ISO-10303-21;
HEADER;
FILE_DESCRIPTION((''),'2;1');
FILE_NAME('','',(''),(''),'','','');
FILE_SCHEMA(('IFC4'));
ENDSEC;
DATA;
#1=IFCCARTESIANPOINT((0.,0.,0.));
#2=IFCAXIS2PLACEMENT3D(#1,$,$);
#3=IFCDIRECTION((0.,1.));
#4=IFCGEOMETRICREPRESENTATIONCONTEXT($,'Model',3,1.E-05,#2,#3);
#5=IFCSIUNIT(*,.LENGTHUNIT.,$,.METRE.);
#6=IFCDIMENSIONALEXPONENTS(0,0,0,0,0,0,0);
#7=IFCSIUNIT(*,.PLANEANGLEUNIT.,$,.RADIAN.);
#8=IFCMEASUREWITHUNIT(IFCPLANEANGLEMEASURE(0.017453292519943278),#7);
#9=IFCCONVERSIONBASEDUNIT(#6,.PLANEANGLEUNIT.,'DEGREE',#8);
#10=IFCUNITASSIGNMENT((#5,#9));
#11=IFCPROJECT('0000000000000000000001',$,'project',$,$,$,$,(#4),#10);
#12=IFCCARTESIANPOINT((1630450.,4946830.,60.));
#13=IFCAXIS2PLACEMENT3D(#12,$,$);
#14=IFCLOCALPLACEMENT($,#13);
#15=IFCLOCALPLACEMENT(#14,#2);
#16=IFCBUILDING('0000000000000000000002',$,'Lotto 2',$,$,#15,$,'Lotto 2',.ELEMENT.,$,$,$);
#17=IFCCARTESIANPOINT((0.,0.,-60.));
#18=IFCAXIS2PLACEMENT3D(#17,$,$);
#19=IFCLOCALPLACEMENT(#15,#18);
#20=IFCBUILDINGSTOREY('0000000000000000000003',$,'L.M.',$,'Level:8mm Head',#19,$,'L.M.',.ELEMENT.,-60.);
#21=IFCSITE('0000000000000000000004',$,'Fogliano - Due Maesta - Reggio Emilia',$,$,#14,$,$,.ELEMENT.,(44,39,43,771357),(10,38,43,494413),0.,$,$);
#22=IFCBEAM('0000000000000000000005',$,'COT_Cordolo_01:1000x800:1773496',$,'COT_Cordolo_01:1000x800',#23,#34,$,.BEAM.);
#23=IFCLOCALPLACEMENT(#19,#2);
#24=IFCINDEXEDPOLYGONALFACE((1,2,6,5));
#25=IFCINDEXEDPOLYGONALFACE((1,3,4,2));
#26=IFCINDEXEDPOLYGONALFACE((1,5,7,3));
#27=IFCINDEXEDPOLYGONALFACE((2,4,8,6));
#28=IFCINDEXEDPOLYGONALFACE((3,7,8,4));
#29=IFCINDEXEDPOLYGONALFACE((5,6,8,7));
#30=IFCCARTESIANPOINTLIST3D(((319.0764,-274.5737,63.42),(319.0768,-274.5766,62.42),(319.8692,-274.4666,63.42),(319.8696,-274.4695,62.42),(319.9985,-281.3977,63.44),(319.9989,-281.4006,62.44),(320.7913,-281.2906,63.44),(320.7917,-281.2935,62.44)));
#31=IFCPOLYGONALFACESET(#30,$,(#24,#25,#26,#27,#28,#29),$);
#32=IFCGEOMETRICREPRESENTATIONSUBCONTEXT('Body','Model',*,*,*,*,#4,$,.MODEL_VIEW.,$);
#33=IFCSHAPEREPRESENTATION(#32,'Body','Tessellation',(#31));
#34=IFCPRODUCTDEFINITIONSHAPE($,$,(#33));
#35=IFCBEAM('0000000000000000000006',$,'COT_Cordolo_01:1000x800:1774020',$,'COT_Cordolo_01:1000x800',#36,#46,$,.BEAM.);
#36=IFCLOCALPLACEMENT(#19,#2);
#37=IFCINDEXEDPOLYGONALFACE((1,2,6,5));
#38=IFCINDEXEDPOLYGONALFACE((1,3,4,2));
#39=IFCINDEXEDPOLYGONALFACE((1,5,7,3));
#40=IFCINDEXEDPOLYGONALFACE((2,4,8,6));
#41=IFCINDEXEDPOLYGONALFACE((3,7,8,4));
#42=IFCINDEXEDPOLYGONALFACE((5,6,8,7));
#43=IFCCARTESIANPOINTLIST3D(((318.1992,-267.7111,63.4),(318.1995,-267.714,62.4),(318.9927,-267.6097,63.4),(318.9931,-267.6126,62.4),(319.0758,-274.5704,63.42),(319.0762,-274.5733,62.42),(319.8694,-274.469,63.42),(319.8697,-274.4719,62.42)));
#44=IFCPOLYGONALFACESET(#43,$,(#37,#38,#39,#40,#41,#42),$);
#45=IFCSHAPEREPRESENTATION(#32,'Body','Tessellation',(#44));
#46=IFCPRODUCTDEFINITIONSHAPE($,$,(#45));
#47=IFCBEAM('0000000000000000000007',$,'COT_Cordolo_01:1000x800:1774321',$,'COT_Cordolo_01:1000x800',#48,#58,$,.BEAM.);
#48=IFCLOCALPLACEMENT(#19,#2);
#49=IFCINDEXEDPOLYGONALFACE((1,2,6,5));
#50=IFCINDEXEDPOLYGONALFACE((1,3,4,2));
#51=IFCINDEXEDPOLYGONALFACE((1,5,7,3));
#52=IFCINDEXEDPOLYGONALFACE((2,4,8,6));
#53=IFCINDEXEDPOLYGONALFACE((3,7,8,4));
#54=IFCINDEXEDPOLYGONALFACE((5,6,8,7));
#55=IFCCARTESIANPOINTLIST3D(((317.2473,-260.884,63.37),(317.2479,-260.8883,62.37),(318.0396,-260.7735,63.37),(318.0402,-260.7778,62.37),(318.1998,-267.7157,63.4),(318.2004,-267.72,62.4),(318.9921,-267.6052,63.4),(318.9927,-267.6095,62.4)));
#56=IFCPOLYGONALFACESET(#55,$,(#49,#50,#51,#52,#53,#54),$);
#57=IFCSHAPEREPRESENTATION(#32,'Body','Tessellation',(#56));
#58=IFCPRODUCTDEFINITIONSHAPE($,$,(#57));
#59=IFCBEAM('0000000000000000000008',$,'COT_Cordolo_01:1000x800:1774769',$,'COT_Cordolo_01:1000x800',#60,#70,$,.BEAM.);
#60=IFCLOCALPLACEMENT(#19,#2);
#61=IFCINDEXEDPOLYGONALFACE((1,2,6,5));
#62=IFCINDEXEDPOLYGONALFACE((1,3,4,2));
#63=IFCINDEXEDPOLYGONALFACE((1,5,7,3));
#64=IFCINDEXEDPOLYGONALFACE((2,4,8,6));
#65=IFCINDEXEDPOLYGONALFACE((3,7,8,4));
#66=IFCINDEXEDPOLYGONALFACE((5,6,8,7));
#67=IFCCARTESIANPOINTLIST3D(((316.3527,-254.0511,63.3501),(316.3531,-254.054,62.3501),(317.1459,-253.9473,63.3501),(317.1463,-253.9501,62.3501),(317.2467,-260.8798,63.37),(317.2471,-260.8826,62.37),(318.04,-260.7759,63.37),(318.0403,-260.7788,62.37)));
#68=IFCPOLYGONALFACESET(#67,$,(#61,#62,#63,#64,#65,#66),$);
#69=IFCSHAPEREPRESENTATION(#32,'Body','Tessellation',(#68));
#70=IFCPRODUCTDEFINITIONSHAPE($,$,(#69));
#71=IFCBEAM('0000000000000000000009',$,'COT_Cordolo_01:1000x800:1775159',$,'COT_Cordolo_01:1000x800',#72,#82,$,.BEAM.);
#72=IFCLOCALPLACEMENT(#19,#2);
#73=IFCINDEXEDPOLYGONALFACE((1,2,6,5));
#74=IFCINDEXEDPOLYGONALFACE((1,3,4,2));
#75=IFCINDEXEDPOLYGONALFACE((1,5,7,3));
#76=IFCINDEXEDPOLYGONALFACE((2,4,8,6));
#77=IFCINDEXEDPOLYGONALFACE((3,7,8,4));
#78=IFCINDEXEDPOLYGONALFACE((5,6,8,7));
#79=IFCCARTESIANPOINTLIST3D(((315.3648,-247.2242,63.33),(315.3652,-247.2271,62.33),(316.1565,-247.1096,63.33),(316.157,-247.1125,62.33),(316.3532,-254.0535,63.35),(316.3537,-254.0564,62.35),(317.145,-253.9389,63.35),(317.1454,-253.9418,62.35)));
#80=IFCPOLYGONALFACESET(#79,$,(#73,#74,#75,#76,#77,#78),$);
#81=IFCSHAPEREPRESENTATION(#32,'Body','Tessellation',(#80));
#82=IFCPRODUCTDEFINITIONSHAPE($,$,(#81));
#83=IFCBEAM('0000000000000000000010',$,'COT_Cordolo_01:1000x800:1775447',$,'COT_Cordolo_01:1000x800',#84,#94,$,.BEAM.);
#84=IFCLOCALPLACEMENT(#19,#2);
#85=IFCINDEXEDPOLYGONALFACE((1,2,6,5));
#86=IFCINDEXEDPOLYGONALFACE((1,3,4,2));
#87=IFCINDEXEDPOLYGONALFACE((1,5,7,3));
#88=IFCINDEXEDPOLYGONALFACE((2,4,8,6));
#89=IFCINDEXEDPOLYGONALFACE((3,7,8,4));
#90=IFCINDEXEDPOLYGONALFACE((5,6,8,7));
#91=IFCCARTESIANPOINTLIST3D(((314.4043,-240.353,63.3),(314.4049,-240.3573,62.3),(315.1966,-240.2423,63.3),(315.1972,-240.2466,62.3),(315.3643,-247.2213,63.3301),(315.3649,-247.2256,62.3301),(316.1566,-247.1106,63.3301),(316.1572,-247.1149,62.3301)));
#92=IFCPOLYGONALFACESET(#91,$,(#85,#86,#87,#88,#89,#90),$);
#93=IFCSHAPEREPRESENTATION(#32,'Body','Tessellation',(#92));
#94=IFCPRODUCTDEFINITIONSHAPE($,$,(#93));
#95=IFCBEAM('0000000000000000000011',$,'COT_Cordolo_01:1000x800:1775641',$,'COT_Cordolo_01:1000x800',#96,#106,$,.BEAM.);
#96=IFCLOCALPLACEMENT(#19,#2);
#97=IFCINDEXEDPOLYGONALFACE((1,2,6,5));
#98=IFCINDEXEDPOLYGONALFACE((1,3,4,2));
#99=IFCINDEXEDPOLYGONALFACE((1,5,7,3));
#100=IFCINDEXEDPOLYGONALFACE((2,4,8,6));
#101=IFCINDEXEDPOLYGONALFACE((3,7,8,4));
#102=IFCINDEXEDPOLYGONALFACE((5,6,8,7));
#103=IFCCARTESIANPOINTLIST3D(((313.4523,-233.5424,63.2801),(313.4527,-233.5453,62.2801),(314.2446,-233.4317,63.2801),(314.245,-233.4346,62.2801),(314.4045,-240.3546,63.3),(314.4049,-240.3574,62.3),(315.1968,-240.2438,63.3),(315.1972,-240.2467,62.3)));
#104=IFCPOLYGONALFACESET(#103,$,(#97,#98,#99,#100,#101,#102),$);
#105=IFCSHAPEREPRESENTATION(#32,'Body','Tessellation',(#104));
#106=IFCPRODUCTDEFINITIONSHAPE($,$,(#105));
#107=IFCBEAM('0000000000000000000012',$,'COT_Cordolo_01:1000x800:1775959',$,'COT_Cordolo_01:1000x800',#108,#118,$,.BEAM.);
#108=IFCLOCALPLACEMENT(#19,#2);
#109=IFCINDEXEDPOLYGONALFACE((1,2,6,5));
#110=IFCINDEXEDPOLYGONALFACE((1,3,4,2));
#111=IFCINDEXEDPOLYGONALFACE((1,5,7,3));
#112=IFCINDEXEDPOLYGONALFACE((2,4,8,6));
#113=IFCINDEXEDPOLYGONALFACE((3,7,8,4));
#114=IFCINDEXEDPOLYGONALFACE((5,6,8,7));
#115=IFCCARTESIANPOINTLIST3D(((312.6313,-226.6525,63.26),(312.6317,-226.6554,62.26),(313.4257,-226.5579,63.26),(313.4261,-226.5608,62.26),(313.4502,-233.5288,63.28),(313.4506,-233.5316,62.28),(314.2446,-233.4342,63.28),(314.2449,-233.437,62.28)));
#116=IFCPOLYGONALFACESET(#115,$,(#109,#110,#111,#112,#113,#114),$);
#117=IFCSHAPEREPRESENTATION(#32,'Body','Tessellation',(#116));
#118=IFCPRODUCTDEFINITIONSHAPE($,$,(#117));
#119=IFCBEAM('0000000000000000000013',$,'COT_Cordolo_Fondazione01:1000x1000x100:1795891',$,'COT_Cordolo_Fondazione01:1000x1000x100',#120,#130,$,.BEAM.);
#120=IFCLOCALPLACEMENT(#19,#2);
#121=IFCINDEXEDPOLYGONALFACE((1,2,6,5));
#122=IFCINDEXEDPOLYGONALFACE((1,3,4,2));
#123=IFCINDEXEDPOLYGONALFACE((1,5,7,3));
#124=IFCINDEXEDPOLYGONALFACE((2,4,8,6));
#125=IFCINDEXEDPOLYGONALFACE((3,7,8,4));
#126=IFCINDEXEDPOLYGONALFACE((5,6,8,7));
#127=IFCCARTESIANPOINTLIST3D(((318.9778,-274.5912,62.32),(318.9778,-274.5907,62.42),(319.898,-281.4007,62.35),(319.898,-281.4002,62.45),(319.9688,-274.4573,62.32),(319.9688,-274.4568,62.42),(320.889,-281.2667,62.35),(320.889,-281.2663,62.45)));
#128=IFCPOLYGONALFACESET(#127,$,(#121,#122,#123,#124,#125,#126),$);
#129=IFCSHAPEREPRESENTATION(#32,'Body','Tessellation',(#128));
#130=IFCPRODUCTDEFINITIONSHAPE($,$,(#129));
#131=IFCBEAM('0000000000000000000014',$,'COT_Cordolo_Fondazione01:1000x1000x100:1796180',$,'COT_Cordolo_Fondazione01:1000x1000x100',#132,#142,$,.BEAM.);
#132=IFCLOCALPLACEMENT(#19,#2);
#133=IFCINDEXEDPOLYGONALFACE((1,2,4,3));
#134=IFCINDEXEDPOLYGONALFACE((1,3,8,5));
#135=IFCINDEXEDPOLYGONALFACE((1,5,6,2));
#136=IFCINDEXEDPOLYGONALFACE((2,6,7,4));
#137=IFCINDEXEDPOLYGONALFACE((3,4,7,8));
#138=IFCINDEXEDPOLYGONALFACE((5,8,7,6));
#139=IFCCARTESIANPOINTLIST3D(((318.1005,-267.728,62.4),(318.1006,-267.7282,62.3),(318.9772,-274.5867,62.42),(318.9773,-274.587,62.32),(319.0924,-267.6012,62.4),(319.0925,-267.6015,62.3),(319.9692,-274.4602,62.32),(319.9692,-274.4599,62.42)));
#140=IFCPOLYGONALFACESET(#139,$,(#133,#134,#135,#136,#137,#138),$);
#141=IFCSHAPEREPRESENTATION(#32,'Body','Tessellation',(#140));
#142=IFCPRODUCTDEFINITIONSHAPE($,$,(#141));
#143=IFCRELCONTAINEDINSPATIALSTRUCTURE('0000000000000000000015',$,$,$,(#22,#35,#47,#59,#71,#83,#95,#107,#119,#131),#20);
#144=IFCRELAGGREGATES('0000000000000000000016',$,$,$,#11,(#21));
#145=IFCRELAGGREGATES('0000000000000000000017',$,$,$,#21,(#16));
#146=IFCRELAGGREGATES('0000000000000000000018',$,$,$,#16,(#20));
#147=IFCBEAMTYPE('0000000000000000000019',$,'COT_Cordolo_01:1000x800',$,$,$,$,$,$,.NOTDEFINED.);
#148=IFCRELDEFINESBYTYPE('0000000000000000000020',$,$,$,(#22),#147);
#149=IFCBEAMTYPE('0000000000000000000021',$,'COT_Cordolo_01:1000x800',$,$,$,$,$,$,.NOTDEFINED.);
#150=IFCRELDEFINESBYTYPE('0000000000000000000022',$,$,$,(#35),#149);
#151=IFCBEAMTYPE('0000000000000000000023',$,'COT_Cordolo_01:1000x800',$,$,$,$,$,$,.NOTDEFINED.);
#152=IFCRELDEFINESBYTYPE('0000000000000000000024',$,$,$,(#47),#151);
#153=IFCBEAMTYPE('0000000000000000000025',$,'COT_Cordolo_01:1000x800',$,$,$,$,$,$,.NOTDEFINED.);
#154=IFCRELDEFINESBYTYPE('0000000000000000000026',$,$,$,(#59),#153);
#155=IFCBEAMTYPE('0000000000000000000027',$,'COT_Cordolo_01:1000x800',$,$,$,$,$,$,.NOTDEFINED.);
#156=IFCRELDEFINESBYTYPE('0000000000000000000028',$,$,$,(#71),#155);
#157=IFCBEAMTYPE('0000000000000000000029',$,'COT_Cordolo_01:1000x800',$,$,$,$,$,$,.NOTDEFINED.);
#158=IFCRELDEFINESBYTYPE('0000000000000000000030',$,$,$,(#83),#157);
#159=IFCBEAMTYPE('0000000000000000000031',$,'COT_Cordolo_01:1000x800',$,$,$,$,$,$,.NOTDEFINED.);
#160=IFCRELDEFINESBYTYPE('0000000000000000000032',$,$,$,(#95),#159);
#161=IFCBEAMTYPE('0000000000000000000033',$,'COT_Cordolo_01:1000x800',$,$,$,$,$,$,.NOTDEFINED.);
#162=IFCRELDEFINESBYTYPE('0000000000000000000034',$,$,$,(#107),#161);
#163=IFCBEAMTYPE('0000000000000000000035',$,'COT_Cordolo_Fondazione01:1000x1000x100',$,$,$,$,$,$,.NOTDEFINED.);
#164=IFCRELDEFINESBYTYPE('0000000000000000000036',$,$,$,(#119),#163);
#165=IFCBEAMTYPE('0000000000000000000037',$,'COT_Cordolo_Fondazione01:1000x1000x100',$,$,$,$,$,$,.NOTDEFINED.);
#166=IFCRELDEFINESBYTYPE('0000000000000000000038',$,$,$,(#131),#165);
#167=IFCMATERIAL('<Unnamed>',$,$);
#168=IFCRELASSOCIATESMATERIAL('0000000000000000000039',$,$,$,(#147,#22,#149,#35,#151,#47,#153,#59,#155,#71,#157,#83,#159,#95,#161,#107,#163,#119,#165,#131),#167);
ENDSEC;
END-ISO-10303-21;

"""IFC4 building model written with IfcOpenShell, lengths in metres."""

from ifc_helpers import new_model, entity, si_unit, converted_unit, direction, frame, origin, place, context, subcontext, project, spatial, indexed_curve, outline, extrude, source, transform, mapped, material, type_object, type_shapes, element, save


model = new_model("IFC4")

# Units and contexts
model_context = context("Model", 3, precision=1e-05, world=origin(), true_north=direction((0.0, 1.0)))
body_context = subcontext(model_context, "Body", "Model", "MODEL_VIEW")
ifc_project = project(units=[si_unit("LENGTHUNIT", "METRE"), converted_unit("PLANEANGLEUNIT", "DEGREE", entity("IfcPlaneAngleMeasure", 0.017453292519943278), si_unit("PLANEANGLEUNIT", "RADIAN"), dimensions=[0, 0, 0, 0, 0, 0, 0])], contexts=[model_context])

# Site, building, storey
site_placement = place(None, frame((1630450.0, 4946830.0, 60.0)))
site = spatial("IfcSite", under=ifc_project, at=site_placement, Name="Fogliano - Due Maesta - Reggio Emilia", CompositionType="ELEMENT", RefLatitude=(44, 39, 43, 771357), RefLongitude=(10, 38, 43, 494413), RefElevation=0.0)
building_placement = place(site_placement, origin())
building = spatial("IfcBuilding", under=site, at=building_placement, Name="Lotto 2", LongName="Lotto 2", CompositionType="ELEMENT")
storey_placement = place(building_placement, frame((0.0, 0.0, -60.0)))
storey = spatial("IfcBuildingStorey", under=building, at=storey_placement, Name="L.M.", ObjectType="Level:8mm Head", LongName="L.M.", CompositionType="ELEMENT", Elevation=-60.0)

# Beams
ifc_material_1 = material(Name="<Unnamed>")
beam_type_1 = type_object("IfcBeamType", Name="COT_Cordolo_01:1000x800", PredefinedType="NOTDEFINED", material=ifc_material_1)
shared_shape_1 = source(origin(), body_context, "Body", "SweptSolid", [
    extrude(outline(indexed_curve([(-3.443, -0.4), (3.443, -0.4), (3.443, 0.4), (-3.443, 0.4), (-3.443, -0.4)], self_intersect=False)), frame((-0.0086, 0.0, -0.5), z_axis=(0.0, 0.0, 1.0), x_axis=(-1.0, 0.0, 0.0)), (0.0, 0.0, 1.0), 1.0),
])
type_shapes(beam_type_1, [shared_shape_1])
beam_1_placement = place(storey_placement, frame((319.9329, -277.9251, 62.93), z_axis=(-0.000388, 0.002872, 0.999996), x_axis=(-0.133917, 0.990988, -0.002899)))
element("IfcBeam", 1, at=beam_1_placement, inside=storey, type_object=beam_type_1, material=ifc_material_1, Name="COT_Cordolo_01:1000x800:1773496", ObjectType="COT_Cordolo_01:1000x800", PredefinedType="BEAM", context=body_context, shape_type="MappedRepresentation", body=[
    mapped(shared_shape_1, transform((0.0, 0.0, 0.0), scale=1.0)),
])
beam_type_2 = type_object("IfcBeamType", Name="COT_Cordolo_01:1000x800", PredefinedType="NOTDEFINED", material=ifc_material_1)
shared_shape_2 = source(origin(), body_context, "Body", "SweptSolid", [
    extrude(outline(indexed_curve([(-3.4576, -0.4), (3.4576, -0.4), (3.4576, 0.4), (-3.4576, 0.4), (-3.4576, -0.4)], self_intersect=False)), frame((-0.0076, 0.0, -0.5), z_axis=(0.0, 0.0, 1.0), x_axis=(-1.0, 0.0, 0.0)), (0.0, 0.0, 1.0), 1.0),
])
type_shapes(beam_type_2, [shared_shape_2])
beam_2_placement = place(storey_placement, frame((319.0335, -271.084, 62.91), z_axis=(-0.000367, 0.002875, 0.999996), x_axis=(-0.126774, 0.991927, -0.002899)))
element("IfcBeam", 2, at=beam_2_placement, inside=storey, type_object=beam_type_2, material=ifc_material_1, Name="COT_Cordolo_01:1000x800:1774020", ObjectType="COT_Cordolo_01:1000x800", PredefinedType="BEAM", context=body_context, shape_type="MappedRepresentation", body=[
    mapped(shared_shape_2, transform((0.0, 0.0, 0.0), scale=1.0)),
])
beam_type_3 = type_object("IfcBeamType", Name="COT_Cordolo_01:1000x800", PredefinedType="NOTDEFINED", material=ifc_material_1)
shared_shape_3 = source(origin(), body_context, "Body", "SweptSolid", [
    extrude(outline(indexed_curve([(-3.4489, -0.4), (3.4489, -0.4), (3.4489, 0.4), (-3.4489, 0.4), (-3.4489, -0.4)], self_intersect=False)), frame((0.0, 0.0, -0.5), z_axis=(0.0, 0.0, 1.0), x_axis=(-1.0, 0.0, 0.0)), (0.0, 0.0, 1.0), 1.0),
])
type_shapes(beam_type_3, [shared_shape_3])
beam_3_placement = place(storey_placement, frame((318.12, -264.2467, 62.885), z_axis=(-0.0006, 0.004306, 0.999991), x_axis=(-0.138084, 0.990411, -0.004348)))
element("IfcBeam", 3, at=beam_3_placement, inside=storey, type_object=beam_type_3, material=ifc_material_1, Name="COT_Cordolo_01:1000x800:1774321", ObjectType="COT_Cordolo_01:1000x800", PredefinedType="BEAM", context=body_context, shape_type="MappedRepresentation", body=[
    mapped(shared_shape_3, transform((0.0, 0.0, 0.0), scale=1.0)),
])
beam_type_4 = type_object("IfcBeamType", Name="COT_Cordolo_01:1000x800", PredefinedType="NOTDEFINED", material=ifc_material_1)
shared_shape_4 = source(origin(), body_context, "Body", "SweptSolid", [
    extrude(outline(indexed_curve([(-3.4435, -0.4), (3.4435, -0.4), (3.4435, 0.4), (-3.4435, 0.4), (-3.4435, -0.4)], self_intersect=False)), frame((-0.0086, 0.0, -0.5), z_axis=(0.0, 0.0, 1.0), x_axis=(-1.0, 0.0, 0.0)), (0.0, 0.0, 1.0), 1.0),
])
type_shapes(beam_type_4, [shared_shape_4])
beam_4_placement = place(storey_placement, frame((317.1954, -257.4064, 62.86), z_axis=(-0.000376, 0.002873, 0.999996), x_axis=(-0.129819, 0.991534, -0.002897)))
element("IfcBeam", 4, at=beam_4_placement, inside=storey, type_object=beam_type_4, material=ifc_material_1, Name="COT_Cordolo_01:1000x800:1774769", ObjectType="COT_Cordolo_01:1000x800", PredefinedType="BEAM", context=body_context, shape_type="MappedRepresentation", body=[
    mapped(shared_shape_4, transform((0.0, 0.0, 0.0), scale=1.0)),
])
beam_type_5 = type_object("IfcBeamType", Name="COT_Cordolo_01:1000x800", PredefinedType="NOTDEFINED", material=ifc_material_1)
shared_shape_5 = source(origin(), body_context, "Body", "SweptSolid", [
    extrude(outline(indexed_curve([(-3.4502, -0.4), (3.4502, -0.4), (3.4502, 0.4), (-3.4502, 0.4), (-3.4502, -0.4)], self_intersect=False)), frame((-0.0149, 0.0, -0.5), z_axis=(0.0, 0.0, 1.0), x_axis=(-1.0, 0.0, 0.0)), (0.0, 0.0, 1.0), 1.0),
])
type_shapes(beam_type_5, [shared_shape_5])
beam_5_placement = place(storey_placement, frame((316.253, -250.5682, 62.84), z_axis=(-0.000415, 0.002869, 0.999996), x_axis=(-0.143244, 0.989683, -0.002899)))
element("IfcBeam", 5, at=beam_5_placement, inside=storey, type_object=beam_type_5, material=ifc_material_1, Name="COT_Cordolo_01:1000x800:1775159", ObjectType="COT_Cordolo_01:1000x800", PredefinedType="BEAM", context=body_context, shape_type="MappedRepresentation", body=[
    mapped(shared_shape_5, transform((0.0, 0.0, 0.0), scale=1.0)),
])
beam_type_6 = type_object("IfcBeamType", Name="COT_Cordolo_01:1000x800", PredefinedType="NOTDEFINED", material=ifc_material_1)
shared_shape_6 = source(origin(), body_context, "Body", "SweptSolid", [
    extrude(outline(indexed_curve([(-3.4676, -0.4), (3.4676, -0.4), (3.4676, 0.4), (-3.4676, 0.4), (-3.4676, -0.4)], self_intersect=False)), frame((-0.0057, 0.0, -0.5), z_axis=(0.0, 0.0, 1.0), x_axis=(-1.0, 0.0, 0.0)), (0.0, 0.0, 1.0), 1.0),
])
type_shapes(beam_type_6, [shared_shape_6])
beam_6_placement = place(storey_placement, frame((315.28, -243.7283, 62.815), z_axis=(-0.0006, 0.004294, 0.999991), x_axis=(-0.138428, 0.990363, -0.004335)))
element("IfcBeam", 6, at=beam_6_placement, inside=storey, type_object=beam_type_6, material=ifc_material_1, Name="COT_Cordolo_01:1000x800:1775447", ObjectType="COT_Cordolo_01:1000x800", PredefinedType="BEAM", context=body_context, shape_type="MappedRepresentation", body=[
    mapped(shared_shape_6, transform((0.0, 0.0, 0.0), scale=1.0)),
])
beam_type_7 = type_object("IfcBeamType", Name="COT_Cordolo_01:1000x800", PredefinedType="NOTDEFINED", material=ifc_material_1)
shared_shape_7 = source(origin(), body_context, "Body", "SweptSolid", [
    extrude(outline(indexed_curve([(-3.4392, -0.4), (3.4392, -0.4), (3.4392, 0.4), (-3.4392, 0.4), (-3.4392, -0.4)], self_intersect=False)), frame((-0.01, 0.0, -0.5), z_axis=(0.0, 0.0, 1.0), x_axis=(-1.0, 0.0, 0.0)), (0.0, 0.0, 1.0), 1.0),
])
type_shapes(beam_type_7, [shared_shape_7])
beam_7_placement = place(storey_placement, frame((314.3234, -236.8846, 62.79), z_axis=(-0.000401, 0.002871, 0.999996), x_axis=(-0.138428, 0.990368, -0.002899)))
element("IfcBeam", 7, at=beam_7_placement, inside=storey, type_object=beam_type_7, material=ifc_material_1, Name="COT_Cordolo_01:1000x800:1775641", ObjectType="COT_Cordolo_01:1000x800", PredefinedType="BEAM", context=body_context, shape_type="MappedRepresentation", body=[
    mapped(shared_shape_7, transform((0.0, 0.0, 0.0), scale=1.0)),
])
beam_type_8 = type_object("IfcBeamType", Name="COT_Cordolo_01:1000x800", PredefinedType="NOTDEFINED", material=ifc_material_1)
shared_shape_8 = source(origin(), body_context, "Body", "SweptSolid", [
    extrude(outline(indexed_curve([(-3.4624, -0.4), (3.4624, -0.4), (3.4624, 0.4), (-3.4624, 0.4), (-3.4624, -0.4)], self_intersect=False)), frame((-0.0064, 0.0, -0.5), z_axis=(0.0, 0.0, 1.0), x_axis=(-1.0, 0.0, 0.0)), (0.0, 0.0, 1.0), 1.0),
])
type_shapes(beam_type_8, [shared_shape_8])
beam_8_placement = place(storey_placement, frame((313.4374, -230.0384, 62.77), z_axis=(-0.000342, 0.002875, 0.999996), x_axis=(-0.118253, 0.992979, -0.002895)))
element("IfcBeam", 8, at=beam_8_placement, inside=storey, type_object=beam_type_8, material=ifc_material_1, Name="COT_Cordolo_01:1000x800:1775959", ObjectType="COT_Cordolo_01:1000x800", PredefinedType="BEAM", context=body_context, shape_type="MappedRepresentation", body=[
    mapped(shared_shape_8, transform((0.0, 0.0, 0.0), scale=1.0)),
])
beam_type_9 = type_object("IfcBeamType", Name="COT_Cordolo_Fondazione01:1000x1000x100", PredefinedType="NOTDEFINED", material=ifc_material_1)
shared_shape_9 = source(origin(), body_context, "Body", "SweptSolid", [
    extrude(outline(indexed_curve([(-3.4357, -0.5), (3.4357, -0.5), (3.4357, 0.5), (-3.4357, 0.5), (-3.4357, -0.5)], self_intersect=False)), frame((0.0043, 0.0, -0.05), z_axis=(0.0, 0.0, 1.0), x_axis=(-1.0, 0.0, 0.0)), (0.0, 0.0, 1.0), 0.1),
])
type_shapes(beam_type_9, [shared_shape_9])
beam_9_placement = place(storey_placement, frame((319.934, -277.933, 62.385), z_axis=(-0.000585, 0.004326, 0.99999), x_axis=(-0.133917, 0.990983, -0.004365)))
element("IfcBeam", 9, at=beam_9_placement, inside=storey, type_object=beam_type_9, material=ifc_material_1, Name="COT_Cordolo_Fondazione01:1000x1000x100:1795891", ObjectType="COT_Cordolo_Fondazione01:1000x1000x100", PredefinedType="BEAM", context=body_context, shape_type="MappedRepresentation", body=[
    mapped(shared_shape_9, transform((0.0, 0.0, 0.0), scale=1.0)),
])
beam_type_10 = type_object("IfcBeamType", Name="COT_Cordolo_Fondazione01:1000x1000x100", PredefinedType="NOTDEFINED", material=ifc_material_1)
shared_shape_10 = source(origin(), body_context, "Body", "SweptSolid", [
    extrude(outline(indexed_curve([(-3.4573, -0.5), (3.4573, -0.5), (3.4573, 0.5), (-3.4573, 0.5), (-3.4573, -0.5)], self_intersect=False)), frame((-0.0023, 0.0, -0.05), z_axis=(0.0, 0.0, 1.0), x_axis=(-1.0, 0.0, 0.0)), (0.0, 0.0, 1.0), 0.1),
])
type_shapes(beam_type_10, [shared_shape_10])
beam_10_placement = place(storey_placement, frame((319.0346, -271.0918, 62.36), z_axis=(-0.000367, 0.002869, 0.999996), x_axis=(-0.126792, 0.991925, -0.002892)))
element("IfcBeam", 10, at=beam_10_placement, inside=storey, type_object=beam_type_10, material=ifc_material_1, Name="COT_Cordolo_Fondazione01:1000x1000x100:1796180", ObjectType="COT_Cordolo_Fondazione01:1000x1000x100", PredefinedType="BEAM", context=body_context, shape_type="MappedRepresentation", body=[
    mapped(shared_shape_10, transform((0.0, 0.0, 0.0), scale=1.0)),
])

save(model, "model.ifc")
